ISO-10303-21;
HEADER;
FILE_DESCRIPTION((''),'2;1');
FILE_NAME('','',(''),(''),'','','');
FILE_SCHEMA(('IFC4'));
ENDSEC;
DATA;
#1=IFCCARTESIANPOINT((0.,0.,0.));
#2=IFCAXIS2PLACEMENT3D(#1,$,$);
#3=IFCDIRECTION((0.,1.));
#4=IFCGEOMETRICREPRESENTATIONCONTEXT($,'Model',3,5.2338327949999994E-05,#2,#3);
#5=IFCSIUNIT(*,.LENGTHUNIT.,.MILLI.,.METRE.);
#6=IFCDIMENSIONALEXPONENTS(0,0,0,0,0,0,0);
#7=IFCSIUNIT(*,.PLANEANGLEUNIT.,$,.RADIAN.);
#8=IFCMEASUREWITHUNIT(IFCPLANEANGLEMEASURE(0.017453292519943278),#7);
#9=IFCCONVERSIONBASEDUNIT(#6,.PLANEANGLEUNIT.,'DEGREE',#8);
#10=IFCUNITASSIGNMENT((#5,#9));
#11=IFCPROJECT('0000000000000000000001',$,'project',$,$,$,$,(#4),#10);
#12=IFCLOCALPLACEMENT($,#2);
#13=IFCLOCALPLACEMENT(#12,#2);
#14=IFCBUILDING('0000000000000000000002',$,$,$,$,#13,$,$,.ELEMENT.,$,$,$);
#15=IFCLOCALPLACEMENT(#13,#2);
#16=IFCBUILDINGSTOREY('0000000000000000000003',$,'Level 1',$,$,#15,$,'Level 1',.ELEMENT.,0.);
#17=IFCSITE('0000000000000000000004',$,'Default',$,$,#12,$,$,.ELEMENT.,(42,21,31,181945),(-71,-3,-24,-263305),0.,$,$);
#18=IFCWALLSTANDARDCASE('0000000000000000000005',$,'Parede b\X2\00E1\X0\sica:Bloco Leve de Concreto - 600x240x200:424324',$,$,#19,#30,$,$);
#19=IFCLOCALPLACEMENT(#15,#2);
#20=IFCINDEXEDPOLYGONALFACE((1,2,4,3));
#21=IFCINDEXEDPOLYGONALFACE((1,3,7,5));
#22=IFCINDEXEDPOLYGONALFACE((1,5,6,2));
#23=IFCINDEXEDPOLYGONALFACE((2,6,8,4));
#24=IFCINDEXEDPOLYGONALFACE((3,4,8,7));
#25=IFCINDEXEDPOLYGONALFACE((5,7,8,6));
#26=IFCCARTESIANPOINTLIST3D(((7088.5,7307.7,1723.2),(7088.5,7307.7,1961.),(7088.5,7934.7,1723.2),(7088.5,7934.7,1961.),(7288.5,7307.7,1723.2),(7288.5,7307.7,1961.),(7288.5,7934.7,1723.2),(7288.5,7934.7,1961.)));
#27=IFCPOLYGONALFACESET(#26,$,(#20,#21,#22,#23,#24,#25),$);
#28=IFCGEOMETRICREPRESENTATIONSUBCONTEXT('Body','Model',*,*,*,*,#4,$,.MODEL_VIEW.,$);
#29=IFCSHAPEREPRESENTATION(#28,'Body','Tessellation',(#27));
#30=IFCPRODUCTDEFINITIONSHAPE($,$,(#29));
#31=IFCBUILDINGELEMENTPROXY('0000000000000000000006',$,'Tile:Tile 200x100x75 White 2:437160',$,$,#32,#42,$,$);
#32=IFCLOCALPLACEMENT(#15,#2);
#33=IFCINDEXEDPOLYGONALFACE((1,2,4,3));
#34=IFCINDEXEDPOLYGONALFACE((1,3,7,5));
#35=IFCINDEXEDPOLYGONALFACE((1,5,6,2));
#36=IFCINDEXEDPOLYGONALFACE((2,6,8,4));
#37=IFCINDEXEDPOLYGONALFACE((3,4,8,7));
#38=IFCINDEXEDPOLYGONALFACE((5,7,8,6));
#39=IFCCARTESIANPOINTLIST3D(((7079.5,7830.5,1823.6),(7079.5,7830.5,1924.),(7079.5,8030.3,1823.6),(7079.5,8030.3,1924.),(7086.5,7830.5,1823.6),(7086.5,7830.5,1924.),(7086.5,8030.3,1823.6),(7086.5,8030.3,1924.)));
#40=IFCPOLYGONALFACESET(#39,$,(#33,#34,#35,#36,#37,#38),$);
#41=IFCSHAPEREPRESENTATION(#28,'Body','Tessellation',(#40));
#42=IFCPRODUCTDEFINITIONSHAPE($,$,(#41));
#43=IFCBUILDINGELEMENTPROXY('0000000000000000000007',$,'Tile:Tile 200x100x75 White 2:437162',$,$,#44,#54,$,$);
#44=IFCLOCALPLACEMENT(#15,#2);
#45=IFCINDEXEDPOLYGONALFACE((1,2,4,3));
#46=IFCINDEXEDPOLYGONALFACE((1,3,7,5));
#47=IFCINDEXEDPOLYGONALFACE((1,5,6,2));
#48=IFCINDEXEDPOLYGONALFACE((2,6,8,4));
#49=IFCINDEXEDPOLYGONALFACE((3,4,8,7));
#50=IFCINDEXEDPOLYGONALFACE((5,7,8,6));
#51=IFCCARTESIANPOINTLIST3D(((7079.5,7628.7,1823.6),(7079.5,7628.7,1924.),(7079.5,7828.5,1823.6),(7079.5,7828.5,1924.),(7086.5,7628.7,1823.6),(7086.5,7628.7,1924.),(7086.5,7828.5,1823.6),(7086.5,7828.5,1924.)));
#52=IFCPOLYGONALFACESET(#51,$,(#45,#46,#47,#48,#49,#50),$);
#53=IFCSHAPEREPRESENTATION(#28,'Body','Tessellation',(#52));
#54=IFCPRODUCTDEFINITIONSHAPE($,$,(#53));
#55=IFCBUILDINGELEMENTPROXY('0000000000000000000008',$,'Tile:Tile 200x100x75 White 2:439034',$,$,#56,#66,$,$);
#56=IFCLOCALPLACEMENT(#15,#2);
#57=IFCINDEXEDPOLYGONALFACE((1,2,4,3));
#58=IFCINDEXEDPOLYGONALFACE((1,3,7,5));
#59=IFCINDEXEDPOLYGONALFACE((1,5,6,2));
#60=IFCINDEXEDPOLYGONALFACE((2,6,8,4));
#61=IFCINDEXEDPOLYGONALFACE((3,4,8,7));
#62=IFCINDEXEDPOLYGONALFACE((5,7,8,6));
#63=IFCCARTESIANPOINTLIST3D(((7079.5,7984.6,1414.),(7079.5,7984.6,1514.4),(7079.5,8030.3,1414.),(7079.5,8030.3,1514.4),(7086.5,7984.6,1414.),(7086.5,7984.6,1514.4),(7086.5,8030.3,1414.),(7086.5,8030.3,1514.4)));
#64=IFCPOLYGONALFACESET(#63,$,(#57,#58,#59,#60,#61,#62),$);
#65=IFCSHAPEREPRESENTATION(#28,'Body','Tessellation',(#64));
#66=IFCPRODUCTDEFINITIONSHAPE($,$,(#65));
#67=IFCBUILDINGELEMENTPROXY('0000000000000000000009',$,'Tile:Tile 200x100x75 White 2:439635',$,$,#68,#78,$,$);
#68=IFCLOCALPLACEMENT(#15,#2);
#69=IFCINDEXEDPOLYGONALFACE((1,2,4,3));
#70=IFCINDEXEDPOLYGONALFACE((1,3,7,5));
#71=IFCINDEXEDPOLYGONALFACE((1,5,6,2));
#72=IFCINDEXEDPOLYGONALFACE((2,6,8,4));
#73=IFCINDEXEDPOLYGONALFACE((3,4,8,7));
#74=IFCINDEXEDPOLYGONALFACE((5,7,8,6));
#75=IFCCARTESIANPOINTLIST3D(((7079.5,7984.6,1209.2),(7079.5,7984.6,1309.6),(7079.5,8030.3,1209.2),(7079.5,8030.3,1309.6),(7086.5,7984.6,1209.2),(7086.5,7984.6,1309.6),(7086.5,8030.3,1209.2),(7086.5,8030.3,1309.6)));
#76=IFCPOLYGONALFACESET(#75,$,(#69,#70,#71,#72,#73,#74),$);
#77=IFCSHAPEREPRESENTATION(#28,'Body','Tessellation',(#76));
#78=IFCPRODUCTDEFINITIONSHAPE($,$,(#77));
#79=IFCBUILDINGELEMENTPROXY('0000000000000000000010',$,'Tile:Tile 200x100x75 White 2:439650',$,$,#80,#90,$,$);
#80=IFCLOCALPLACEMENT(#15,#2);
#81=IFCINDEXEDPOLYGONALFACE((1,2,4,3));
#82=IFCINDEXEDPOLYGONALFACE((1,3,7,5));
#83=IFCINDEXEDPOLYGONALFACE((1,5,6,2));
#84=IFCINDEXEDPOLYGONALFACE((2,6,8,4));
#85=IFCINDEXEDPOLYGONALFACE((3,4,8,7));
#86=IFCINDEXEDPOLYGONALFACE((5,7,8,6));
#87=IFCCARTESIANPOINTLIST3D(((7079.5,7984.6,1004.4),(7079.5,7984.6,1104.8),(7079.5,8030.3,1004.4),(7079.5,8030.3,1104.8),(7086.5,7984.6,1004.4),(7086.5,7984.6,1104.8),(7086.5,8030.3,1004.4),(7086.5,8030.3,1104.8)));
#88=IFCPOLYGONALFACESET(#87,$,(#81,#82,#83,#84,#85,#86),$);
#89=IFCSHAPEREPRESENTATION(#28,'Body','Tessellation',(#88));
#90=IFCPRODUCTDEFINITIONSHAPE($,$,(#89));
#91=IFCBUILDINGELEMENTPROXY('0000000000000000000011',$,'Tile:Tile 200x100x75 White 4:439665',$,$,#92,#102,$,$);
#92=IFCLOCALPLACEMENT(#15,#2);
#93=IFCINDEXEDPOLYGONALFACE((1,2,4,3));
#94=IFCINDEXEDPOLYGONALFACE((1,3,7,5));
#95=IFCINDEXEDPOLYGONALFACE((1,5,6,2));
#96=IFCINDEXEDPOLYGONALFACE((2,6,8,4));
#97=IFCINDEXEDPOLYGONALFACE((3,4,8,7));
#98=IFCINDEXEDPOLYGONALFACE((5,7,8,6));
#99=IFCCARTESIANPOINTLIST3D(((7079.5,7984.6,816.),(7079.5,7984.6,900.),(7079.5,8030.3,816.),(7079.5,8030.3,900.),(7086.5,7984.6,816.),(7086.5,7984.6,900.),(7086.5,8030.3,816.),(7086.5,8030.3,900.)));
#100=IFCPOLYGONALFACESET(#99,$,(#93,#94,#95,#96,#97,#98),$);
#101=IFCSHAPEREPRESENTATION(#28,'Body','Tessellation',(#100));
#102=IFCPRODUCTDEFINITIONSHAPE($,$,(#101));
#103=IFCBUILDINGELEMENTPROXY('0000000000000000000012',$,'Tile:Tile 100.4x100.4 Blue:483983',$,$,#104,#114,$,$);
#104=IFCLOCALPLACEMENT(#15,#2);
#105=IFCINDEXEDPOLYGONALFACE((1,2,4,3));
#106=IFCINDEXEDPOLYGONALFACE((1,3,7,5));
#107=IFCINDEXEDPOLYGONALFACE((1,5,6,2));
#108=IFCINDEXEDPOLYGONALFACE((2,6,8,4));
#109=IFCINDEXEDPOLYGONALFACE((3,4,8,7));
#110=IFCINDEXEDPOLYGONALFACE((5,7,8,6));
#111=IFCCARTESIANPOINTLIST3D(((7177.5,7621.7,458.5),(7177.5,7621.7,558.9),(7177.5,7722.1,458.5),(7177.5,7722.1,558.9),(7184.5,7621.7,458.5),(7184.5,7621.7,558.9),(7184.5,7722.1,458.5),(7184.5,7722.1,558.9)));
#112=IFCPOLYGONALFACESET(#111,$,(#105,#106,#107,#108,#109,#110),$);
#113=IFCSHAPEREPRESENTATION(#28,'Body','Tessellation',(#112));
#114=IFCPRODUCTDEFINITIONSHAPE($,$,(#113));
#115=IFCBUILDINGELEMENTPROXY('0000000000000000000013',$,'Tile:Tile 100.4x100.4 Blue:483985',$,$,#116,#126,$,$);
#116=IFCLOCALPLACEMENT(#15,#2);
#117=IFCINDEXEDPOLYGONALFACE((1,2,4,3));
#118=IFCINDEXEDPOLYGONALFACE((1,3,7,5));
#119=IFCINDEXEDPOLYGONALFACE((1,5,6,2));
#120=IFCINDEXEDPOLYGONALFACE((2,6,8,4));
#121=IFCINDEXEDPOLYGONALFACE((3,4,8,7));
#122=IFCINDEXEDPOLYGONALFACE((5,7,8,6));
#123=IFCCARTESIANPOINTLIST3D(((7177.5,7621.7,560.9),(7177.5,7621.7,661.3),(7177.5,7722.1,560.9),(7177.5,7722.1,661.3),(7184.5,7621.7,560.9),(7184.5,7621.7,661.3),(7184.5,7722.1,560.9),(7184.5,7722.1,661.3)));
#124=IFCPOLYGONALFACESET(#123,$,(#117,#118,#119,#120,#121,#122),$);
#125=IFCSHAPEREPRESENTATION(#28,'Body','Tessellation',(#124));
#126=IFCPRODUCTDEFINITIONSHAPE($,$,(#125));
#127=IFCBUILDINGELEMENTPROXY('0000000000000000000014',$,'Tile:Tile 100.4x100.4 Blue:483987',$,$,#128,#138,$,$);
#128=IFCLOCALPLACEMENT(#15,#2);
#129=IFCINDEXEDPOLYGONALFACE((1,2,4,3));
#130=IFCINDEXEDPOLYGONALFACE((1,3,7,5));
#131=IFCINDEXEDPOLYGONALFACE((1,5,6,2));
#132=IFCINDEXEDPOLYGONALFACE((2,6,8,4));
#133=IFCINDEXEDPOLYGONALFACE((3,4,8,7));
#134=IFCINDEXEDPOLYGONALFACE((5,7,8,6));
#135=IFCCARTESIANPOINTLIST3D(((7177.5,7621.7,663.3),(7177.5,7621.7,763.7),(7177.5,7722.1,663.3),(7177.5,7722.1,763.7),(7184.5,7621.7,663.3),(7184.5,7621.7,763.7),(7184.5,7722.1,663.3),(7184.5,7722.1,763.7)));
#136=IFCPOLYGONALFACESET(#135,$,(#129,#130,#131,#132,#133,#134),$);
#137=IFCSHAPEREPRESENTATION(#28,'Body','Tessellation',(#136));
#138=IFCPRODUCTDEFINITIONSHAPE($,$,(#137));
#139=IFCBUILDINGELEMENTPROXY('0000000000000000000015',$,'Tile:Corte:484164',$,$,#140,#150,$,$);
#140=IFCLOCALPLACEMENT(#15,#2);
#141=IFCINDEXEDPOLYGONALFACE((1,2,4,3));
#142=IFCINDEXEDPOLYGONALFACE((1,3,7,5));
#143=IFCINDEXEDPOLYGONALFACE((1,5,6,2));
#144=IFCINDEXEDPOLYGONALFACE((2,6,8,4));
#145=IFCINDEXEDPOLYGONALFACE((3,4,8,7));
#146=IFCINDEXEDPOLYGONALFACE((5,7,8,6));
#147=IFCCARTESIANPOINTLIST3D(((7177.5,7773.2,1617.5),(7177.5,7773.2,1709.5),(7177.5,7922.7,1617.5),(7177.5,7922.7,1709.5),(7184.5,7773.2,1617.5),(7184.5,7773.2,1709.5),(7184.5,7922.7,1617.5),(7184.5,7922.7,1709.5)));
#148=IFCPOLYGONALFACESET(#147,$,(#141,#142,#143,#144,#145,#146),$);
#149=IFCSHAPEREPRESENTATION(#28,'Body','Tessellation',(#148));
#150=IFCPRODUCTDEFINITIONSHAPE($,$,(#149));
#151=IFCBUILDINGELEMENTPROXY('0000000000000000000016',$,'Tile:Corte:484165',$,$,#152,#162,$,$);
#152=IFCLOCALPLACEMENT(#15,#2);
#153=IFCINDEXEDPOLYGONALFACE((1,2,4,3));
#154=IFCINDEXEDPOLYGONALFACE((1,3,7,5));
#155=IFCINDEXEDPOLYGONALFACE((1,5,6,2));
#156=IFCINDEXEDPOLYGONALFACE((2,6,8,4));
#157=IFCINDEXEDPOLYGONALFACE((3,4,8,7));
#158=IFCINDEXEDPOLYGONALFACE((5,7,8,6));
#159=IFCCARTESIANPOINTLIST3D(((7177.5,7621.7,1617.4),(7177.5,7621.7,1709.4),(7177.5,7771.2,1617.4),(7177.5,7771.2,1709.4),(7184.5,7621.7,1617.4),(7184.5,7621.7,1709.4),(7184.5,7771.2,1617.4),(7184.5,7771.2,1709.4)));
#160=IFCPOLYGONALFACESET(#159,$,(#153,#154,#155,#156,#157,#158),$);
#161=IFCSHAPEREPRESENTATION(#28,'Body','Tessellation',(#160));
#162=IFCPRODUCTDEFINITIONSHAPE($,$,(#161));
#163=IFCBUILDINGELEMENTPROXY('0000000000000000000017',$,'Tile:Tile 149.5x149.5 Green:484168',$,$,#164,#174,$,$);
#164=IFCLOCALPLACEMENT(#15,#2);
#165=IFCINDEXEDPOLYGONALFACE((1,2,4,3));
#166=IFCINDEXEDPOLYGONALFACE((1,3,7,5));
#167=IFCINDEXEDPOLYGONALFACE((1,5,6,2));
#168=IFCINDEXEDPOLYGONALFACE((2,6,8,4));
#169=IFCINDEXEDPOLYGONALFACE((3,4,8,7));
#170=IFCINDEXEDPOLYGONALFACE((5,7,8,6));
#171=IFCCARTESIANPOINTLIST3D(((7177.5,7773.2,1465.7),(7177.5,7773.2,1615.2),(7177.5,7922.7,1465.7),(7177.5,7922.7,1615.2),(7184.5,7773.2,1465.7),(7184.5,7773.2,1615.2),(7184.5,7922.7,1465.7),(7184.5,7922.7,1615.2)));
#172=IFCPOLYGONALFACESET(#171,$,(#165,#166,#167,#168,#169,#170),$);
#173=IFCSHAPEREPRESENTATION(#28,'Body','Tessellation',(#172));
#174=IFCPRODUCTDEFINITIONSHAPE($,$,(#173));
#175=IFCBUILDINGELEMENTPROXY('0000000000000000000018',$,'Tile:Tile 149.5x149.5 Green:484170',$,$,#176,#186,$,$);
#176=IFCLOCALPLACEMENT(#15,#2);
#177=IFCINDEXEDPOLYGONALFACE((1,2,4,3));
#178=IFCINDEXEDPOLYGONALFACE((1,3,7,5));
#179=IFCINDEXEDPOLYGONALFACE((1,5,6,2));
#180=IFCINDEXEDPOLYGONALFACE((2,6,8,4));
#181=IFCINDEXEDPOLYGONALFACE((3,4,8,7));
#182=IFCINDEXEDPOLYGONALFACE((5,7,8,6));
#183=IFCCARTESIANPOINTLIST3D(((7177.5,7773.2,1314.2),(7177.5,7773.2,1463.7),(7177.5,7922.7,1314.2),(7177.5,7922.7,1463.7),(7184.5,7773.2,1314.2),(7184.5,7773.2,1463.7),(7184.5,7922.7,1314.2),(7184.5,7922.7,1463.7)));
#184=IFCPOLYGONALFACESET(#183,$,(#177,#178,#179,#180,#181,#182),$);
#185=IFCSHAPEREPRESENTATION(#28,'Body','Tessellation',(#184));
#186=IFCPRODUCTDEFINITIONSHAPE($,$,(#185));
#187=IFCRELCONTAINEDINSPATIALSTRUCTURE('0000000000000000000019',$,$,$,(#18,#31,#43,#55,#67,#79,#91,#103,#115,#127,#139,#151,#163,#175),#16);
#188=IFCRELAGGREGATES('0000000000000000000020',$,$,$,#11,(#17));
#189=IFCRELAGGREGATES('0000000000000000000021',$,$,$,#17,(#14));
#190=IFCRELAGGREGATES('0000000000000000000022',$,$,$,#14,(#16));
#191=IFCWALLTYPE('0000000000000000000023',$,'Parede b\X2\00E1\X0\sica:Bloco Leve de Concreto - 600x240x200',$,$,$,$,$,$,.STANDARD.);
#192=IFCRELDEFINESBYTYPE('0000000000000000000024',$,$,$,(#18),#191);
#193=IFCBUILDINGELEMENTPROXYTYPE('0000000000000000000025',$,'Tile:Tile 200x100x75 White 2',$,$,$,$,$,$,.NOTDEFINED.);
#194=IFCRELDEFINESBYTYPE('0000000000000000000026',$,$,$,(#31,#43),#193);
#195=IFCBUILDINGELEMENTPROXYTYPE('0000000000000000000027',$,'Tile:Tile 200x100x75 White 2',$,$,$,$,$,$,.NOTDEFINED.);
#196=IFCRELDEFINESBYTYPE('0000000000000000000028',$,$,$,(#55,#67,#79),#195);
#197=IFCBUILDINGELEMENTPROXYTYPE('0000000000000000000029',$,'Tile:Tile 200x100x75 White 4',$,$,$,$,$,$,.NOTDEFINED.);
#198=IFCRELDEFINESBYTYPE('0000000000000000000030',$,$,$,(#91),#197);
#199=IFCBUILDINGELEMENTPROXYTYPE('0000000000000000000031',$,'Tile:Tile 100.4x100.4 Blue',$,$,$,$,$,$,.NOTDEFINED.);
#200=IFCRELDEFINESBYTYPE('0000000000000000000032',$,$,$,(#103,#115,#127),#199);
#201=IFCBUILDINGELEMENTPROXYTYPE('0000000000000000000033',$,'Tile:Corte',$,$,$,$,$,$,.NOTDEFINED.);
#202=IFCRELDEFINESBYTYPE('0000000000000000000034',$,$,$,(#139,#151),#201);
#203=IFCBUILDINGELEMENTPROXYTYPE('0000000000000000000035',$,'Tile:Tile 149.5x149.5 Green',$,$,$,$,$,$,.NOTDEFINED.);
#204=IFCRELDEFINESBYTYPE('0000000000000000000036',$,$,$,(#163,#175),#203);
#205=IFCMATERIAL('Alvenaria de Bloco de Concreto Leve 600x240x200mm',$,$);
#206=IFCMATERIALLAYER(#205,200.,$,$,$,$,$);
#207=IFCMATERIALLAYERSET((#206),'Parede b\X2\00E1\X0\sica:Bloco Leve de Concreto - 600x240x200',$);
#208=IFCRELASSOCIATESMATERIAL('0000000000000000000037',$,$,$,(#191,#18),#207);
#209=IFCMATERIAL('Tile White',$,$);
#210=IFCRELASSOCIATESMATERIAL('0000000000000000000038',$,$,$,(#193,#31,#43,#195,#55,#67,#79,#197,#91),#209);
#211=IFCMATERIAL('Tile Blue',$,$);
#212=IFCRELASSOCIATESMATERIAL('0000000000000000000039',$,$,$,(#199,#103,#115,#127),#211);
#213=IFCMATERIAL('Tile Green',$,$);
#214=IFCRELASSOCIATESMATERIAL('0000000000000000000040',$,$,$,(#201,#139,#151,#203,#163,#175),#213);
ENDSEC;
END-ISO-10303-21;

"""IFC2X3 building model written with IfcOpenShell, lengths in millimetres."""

from ifc_helpers import new_model, entity, si_unit, converted_unit, direction, frame, frame_2d, origin, origin_2d_with_axis, place, context, subcontext, project, spatial, rectangle, extrude, source, transform, mapped, material, layer, layer_set, layer_usage, type_object, type_shapes, element, save


model = new_model("IFC2X3")

# Units and contexts
model_context = context("Model", 3, precision=5.2338327949999994e-05, world=origin(), true_north=direction((0.0, 1.0)))
body_context = subcontext(model_context, "Body", "Model", "MODEL_VIEW")
ifc_project = project(units=[si_unit("LENGTHUNIT", "METRE", prefix="MILLI"), converted_unit("PLANEANGLEUNIT", "DEGREE", entity("IfcPlaneAngleMeasure", 0.017453292519943278), si_unit("PLANEANGLEUNIT", "RADIAN"), dimensions=[0, 0, 0, 0, 0, 0, 0])], contexts=[model_context])

# Site, building, storey
site_placement = place(None, origin())
site = spatial("IfcSite", under=ifc_project, at=site_placement, Name="Default", CompositionType="ELEMENT", RefLatitude=(42, 21, 31, 181945), RefLongitude=(-71, -3, -24, -263305), RefElevation=0.0)
building_placement = place(site_placement, origin())
building = spatial("IfcBuilding", under=site, at=building_placement, CompositionType="ELEMENT")
storey_placement = place(building_placement, origin())
storey = spatial("IfcBuildingStorey", under=building, at=storey_placement, Name="Level 1", LongName="Level 1", CompositionType="ELEMENT", Elevation=0.0)

# Wall
ifc_material_1 = material(Name="Alvenaria de Bloco de Concreto Leve 600x240x200mm")
ifc_layer = layer(ifc_material_1, 200.0)
ifc_layer_set = layer_set([ifc_layer], Name="Parede básica:Bloco Leve de Concreto - 600x240x200")
ifc_layer_usage = layer_usage(ifc_layer_set, "AXIS2", "NEGATIVE", 100.0)
wall_type = type_object("IfcWallType", Name="Parede básica:Bloco Leve de Concreto - 600x240x200", PredefinedType="STANDARD", material=ifc_layer_set)
wall_placement = place(storey_placement, frame((7188.5, 7934.7, 1723.2), z_axis=(0.0, 0.0, 1.0), x_axis=(0.0, -1.0, 0.0)))
element("IfcWallStandardCase", 1, at=wall_placement, inside=storey, type_object=wall_type, material=ifc_layer_usage, Name="Parede básica:Bloco Leve de Concreto - 600x240x200:424324", context=body_context, shape_type="SweptSolid", body=[
    extrude(rectangle(XDim=627.0, YDim=200.0, at=frame_2d((313.5, 0.0), x_axis=(-1.0, 0.0))), origin(), (0.0, 0.0, 1.0), 237.8),
])

# Building element proxies
ifc_material_2 = material(Name="Tile White")
building_element_proxy_type_1 = type_object("IfcBuildingElementProxyType", Name="Tile:Tile 200x100x75 White 2", PredefinedType="NOTDEFINED", material=ifc_material_2)
shared_shape_1 = source(origin(), body_context, "Body", "SweptSolid", [
    extrude(rectangle(XDim=199.8, YDim=100.4, at=frame_2d((0.0, 0.0), x_axis=(1.0, 0.0))), frame((-50.2, -99.9, 0.0), z_axis=(0.0, 0.0, 1.0), x_axis=(0.0, -1.0, 0.0)), (0.0, 0.0, 1.0), 7.0),
])
type_shapes(building_element_proxy_type_1, [shared_shape_1])
for number, where, z_axis, x_axis, name in (
    (2, (7086.5, 8030.3, 1924.0), (-1.0, 0.0, 0.0), (0.0, 0.0, 1.0), "Tile:Tile 200x100x75 White 2:437160"),
    (3, (7086.5, 7828.5, 1924.0), (-1.0, 0.0, 0.0), (0.0, 0.0, 1.0), "Tile:Tile 200x100x75 White 2:437162"),
):
    element("IfcBuildingElementProxy", number, at=place(storey_placement, frame(where, z_axis=z_axis, x_axis=x_axis)), inside=storey, type_object=building_element_proxy_type_1, material=ifc_material_2, Name=name, context=body_context, shape_type="MappedRepresentation", body=[
        mapped(shared_shape_1, transform((0.0, 0.0, 0.0), scale=1.0)),
    ])
building_element_proxy_type_2 = type_object("IfcBuildingElementProxyType", Name="Tile:Tile 200x100x75 White 2", PredefinedType="NOTDEFINED", material=ifc_material_2)
shared_shape_2 = source(origin(), body_context, "Body", "SweptSolid", [
    extrude(rectangle(XDim=45.7, YDim=100.4, at=frame_2d((0.0, 0.0), x_axis=(1.0, 0.0))), frame((-50.2, -22.9, 0.0), z_axis=(0.0, 0.0, 1.0), x_axis=(0.0, -1.0, 0.0)), (0.0, 0.0, 1.0), 7.0),
])
type_shapes(building_element_proxy_type_2, [shared_shape_2])
for number, where, z_axis, x_axis, name in (
    (4, (7086.5, 8030.3, 1514.4), (-1.0, 0.0, 0.0), (0.0, 0.0, 1.0), "Tile:Tile 200x100x75 White 2:439034"),
    (5, (7086.5, 8030.3, 1309.6), (-1.0, 0.0, 0.0), (0.0, 0.0, 1.0), "Tile:Tile 200x100x75 White 2:439635"),
    (6, (7086.5, 8030.3, 1104.8), (-1.0, 0.0, 0.0), (0.0, 0.0, 1.0), "Tile:Tile 200x100x75 White 2:439650"),
):
    element("IfcBuildingElementProxy", number, at=place(storey_placement, frame(where, z_axis=z_axis, x_axis=x_axis)), inside=storey, type_object=building_element_proxy_type_2, material=ifc_material_2, Name=name, context=body_context, shape_type="MappedRepresentation", body=[
        mapped(shared_shape_2, transform((0.0, 0.0, 0.0), scale=1.0)),
    ])
building_element_proxy_type_3 = type_object("IfcBuildingElementProxyType", Name="Tile:Tile 200x100x75 White 4", PredefinedType="NOTDEFINED", material=ifc_material_2)
shared_shape_3 = source(origin(), body_context, "Body", "SweptSolid", [
    extrude(rectangle(XDim=45.7, YDim=84.0, at=origin_2d_with_axis()), frame((-42.0, -22.9, 0.0), z_axis=(0.0, 0.0, 1.0), x_axis=(0.0, -1.0, 0.0)), (0.0, 0.0, 1.0), 7.0),
])
type_shapes(building_element_proxy_type_3, [shared_shape_3])
proxy_placement = place(storey_placement, frame((7086.5, 8030.3, 900.0), z_axis=(-1.0, 0.0, 0.0), x_axis=(0.0, 0.0, 1.0)))
element("IfcBuildingElementProxy", 7, at=proxy_placement, inside=storey, type_object=building_element_proxy_type_3, material=ifc_material_2, Name="Tile:Tile 200x100x75 White 4:439665", context=body_context, shape_type="MappedRepresentation", body=[
    mapped(shared_shape_3, transform((0.0, 0.0, 0.0), scale=1.0)),
])
ifc_material_3 = material(Name="Tile Blue")
building_element_proxy_type_4 = type_object("IfcBuildingElementProxyType", Name="Tile:Tile 100.4x100.4 Blue", PredefinedType="NOTDEFINED", material=ifc_material_3)
shared_shape_4 = source(origin(), body_context, "Body", "SweptSolid", [
    extrude(rectangle(XDim=100.4, YDim=100.4, at=origin_2d_with_axis()), frame((-50.2, -50.2, 0.0), z_axis=(0.0, 0.0, 1.0), x_axis=(0.0, -1.0, 0.0)), (0.0, 0.0, 1.0), 7.0),
])
type_shapes(building_element_proxy_type_4, [shared_shape_4])
for number, where, z_axis, x_axis, name in (
    (8, (7184.5, 7722.1, 458.5), (-1.0, 0.0, 0.0), (0.0, 1.0, 0.0), "Tile:Tile 100.4x100.4 Blue:483983"),
    (9, (7184.5, 7722.1, 560.9), (-1.0, 0.0, 0.0), (0.0, 1.0, 0.0), "Tile:Tile 100.4x100.4 Blue:483985"),
    (10, (7184.5, 7722.1, 663.3), (-1.0, 0.0, 0.0), (0.0, 1.0, 0.0), "Tile:Tile 100.4x100.4 Blue:483987"),
):
    element("IfcBuildingElementProxy", number, at=place(storey_placement, frame(where, z_axis=z_axis, x_axis=x_axis)), inside=storey, type_object=building_element_proxy_type_4, material=ifc_material_3, Name=name, context=body_context, shape_type="MappedRepresentation", body=[
        mapped(shared_shape_4, transform((0.0, 0.0, 0.0), scale=1.0)),
    ])
ifc_material_4 = material(Name="Tile Green")
building_element_proxy_type_5 = type_object("IfcBuildingElementProxyType", Name="Tile:Corte", PredefinedType="NOTDEFINED", material=ifc_material_4)
shared_shape_5 = source(origin(), body_context, "Body", "SweptSolid", [
    extrude(rectangle(XDim=149.5, YDim=92.0, at=origin_2d_with_axis()), frame((-46.0, -74.8, 0.0), z_axis=(0.0, 0.0, 1.0), x_axis=(0.0, -1.0, 0.0)), (0.0, 0.0, 1.0), 7.0),
])
type_shapes(building_element_proxy_type_5, [shared_shape_5])
for number, where, z_axis, x_axis, name in (
    (11, (7184.5, 7922.7, 1709.5), (-1.0, 0.0, 0.0), (0.0, 0.0, 1.0), "Tile:Corte:484164"),
    (12, (7184.5, 7771.2, 1709.4), (-1.0, 0.0, 0.0), (0.0, 0.0, 1.0), "Tile:Corte:484165"),
):
    element("IfcBuildingElementProxy", number, at=place(storey_placement, frame(where, z_axis=z_axis, x_axis=x_axis)), inside=storey, type_object=building_element_proxy_type_5, material=ifc_material_4, Name=name, context=body_context, shape_type="MappedRepresentation", body=[
        mapped(shared_shape_5, transform((0.0, 0.0, 0.0), scale=1.0)),
    ])
building_element_proxy_type_6 = type_object("IfcBuildingElementProxyType", Name="Tile:Tile 149.5x149.5 Green", PredefinedType="NOTDEFINED", material=ifc_material_4)
shared_shape_6 = source(origin(), body_context, "Body", "SweptSolid", [
    extrude(rectangle(XDim=149.5, YDim=149.5, at=origin_2d_with_axis()), frame((-74.7, -74.8, 0.0), z_axis=(0.0, 0.0, 1.0), x_axis=(0.0, -1.0, 0.0)), (0.0, 0.0, 1.0), 7.0),
])
type_shapes(building_element_proxy_type_6, [shared_shape_6])
for number, where, z_axis, x_axis, name in (
    (13, (7184.5, 7922.7, 1615.2), (-1.0, 0.0, 0.0), (0.0, 0.0, 1.0), "Tile:Tile 149.5x149.5 Green:484168"),
    (14, (7184.5, 7922.7, 1463.7), (-1.0, 0.0, 0.0), (0.0, 0.0, 1.0), "Tile:Tile 149.5x149.5 Green:484170"),
):
    element("IfcBuildingElementProxy", number, at=place(storey_placement, frame(where, z_axis=z_axis, x_axis=x_axis)), inside=storey, type_object=building_element_proxy_type_6, material=ifc_material_4, Name=name, context=body_context, shape_type="MappedRepresentation", body=[
        mapped(shared_shape_6, transform((0.0, 0.0, 0.0), scale=1.0)),
    ])

save(model, "model.ifc")
